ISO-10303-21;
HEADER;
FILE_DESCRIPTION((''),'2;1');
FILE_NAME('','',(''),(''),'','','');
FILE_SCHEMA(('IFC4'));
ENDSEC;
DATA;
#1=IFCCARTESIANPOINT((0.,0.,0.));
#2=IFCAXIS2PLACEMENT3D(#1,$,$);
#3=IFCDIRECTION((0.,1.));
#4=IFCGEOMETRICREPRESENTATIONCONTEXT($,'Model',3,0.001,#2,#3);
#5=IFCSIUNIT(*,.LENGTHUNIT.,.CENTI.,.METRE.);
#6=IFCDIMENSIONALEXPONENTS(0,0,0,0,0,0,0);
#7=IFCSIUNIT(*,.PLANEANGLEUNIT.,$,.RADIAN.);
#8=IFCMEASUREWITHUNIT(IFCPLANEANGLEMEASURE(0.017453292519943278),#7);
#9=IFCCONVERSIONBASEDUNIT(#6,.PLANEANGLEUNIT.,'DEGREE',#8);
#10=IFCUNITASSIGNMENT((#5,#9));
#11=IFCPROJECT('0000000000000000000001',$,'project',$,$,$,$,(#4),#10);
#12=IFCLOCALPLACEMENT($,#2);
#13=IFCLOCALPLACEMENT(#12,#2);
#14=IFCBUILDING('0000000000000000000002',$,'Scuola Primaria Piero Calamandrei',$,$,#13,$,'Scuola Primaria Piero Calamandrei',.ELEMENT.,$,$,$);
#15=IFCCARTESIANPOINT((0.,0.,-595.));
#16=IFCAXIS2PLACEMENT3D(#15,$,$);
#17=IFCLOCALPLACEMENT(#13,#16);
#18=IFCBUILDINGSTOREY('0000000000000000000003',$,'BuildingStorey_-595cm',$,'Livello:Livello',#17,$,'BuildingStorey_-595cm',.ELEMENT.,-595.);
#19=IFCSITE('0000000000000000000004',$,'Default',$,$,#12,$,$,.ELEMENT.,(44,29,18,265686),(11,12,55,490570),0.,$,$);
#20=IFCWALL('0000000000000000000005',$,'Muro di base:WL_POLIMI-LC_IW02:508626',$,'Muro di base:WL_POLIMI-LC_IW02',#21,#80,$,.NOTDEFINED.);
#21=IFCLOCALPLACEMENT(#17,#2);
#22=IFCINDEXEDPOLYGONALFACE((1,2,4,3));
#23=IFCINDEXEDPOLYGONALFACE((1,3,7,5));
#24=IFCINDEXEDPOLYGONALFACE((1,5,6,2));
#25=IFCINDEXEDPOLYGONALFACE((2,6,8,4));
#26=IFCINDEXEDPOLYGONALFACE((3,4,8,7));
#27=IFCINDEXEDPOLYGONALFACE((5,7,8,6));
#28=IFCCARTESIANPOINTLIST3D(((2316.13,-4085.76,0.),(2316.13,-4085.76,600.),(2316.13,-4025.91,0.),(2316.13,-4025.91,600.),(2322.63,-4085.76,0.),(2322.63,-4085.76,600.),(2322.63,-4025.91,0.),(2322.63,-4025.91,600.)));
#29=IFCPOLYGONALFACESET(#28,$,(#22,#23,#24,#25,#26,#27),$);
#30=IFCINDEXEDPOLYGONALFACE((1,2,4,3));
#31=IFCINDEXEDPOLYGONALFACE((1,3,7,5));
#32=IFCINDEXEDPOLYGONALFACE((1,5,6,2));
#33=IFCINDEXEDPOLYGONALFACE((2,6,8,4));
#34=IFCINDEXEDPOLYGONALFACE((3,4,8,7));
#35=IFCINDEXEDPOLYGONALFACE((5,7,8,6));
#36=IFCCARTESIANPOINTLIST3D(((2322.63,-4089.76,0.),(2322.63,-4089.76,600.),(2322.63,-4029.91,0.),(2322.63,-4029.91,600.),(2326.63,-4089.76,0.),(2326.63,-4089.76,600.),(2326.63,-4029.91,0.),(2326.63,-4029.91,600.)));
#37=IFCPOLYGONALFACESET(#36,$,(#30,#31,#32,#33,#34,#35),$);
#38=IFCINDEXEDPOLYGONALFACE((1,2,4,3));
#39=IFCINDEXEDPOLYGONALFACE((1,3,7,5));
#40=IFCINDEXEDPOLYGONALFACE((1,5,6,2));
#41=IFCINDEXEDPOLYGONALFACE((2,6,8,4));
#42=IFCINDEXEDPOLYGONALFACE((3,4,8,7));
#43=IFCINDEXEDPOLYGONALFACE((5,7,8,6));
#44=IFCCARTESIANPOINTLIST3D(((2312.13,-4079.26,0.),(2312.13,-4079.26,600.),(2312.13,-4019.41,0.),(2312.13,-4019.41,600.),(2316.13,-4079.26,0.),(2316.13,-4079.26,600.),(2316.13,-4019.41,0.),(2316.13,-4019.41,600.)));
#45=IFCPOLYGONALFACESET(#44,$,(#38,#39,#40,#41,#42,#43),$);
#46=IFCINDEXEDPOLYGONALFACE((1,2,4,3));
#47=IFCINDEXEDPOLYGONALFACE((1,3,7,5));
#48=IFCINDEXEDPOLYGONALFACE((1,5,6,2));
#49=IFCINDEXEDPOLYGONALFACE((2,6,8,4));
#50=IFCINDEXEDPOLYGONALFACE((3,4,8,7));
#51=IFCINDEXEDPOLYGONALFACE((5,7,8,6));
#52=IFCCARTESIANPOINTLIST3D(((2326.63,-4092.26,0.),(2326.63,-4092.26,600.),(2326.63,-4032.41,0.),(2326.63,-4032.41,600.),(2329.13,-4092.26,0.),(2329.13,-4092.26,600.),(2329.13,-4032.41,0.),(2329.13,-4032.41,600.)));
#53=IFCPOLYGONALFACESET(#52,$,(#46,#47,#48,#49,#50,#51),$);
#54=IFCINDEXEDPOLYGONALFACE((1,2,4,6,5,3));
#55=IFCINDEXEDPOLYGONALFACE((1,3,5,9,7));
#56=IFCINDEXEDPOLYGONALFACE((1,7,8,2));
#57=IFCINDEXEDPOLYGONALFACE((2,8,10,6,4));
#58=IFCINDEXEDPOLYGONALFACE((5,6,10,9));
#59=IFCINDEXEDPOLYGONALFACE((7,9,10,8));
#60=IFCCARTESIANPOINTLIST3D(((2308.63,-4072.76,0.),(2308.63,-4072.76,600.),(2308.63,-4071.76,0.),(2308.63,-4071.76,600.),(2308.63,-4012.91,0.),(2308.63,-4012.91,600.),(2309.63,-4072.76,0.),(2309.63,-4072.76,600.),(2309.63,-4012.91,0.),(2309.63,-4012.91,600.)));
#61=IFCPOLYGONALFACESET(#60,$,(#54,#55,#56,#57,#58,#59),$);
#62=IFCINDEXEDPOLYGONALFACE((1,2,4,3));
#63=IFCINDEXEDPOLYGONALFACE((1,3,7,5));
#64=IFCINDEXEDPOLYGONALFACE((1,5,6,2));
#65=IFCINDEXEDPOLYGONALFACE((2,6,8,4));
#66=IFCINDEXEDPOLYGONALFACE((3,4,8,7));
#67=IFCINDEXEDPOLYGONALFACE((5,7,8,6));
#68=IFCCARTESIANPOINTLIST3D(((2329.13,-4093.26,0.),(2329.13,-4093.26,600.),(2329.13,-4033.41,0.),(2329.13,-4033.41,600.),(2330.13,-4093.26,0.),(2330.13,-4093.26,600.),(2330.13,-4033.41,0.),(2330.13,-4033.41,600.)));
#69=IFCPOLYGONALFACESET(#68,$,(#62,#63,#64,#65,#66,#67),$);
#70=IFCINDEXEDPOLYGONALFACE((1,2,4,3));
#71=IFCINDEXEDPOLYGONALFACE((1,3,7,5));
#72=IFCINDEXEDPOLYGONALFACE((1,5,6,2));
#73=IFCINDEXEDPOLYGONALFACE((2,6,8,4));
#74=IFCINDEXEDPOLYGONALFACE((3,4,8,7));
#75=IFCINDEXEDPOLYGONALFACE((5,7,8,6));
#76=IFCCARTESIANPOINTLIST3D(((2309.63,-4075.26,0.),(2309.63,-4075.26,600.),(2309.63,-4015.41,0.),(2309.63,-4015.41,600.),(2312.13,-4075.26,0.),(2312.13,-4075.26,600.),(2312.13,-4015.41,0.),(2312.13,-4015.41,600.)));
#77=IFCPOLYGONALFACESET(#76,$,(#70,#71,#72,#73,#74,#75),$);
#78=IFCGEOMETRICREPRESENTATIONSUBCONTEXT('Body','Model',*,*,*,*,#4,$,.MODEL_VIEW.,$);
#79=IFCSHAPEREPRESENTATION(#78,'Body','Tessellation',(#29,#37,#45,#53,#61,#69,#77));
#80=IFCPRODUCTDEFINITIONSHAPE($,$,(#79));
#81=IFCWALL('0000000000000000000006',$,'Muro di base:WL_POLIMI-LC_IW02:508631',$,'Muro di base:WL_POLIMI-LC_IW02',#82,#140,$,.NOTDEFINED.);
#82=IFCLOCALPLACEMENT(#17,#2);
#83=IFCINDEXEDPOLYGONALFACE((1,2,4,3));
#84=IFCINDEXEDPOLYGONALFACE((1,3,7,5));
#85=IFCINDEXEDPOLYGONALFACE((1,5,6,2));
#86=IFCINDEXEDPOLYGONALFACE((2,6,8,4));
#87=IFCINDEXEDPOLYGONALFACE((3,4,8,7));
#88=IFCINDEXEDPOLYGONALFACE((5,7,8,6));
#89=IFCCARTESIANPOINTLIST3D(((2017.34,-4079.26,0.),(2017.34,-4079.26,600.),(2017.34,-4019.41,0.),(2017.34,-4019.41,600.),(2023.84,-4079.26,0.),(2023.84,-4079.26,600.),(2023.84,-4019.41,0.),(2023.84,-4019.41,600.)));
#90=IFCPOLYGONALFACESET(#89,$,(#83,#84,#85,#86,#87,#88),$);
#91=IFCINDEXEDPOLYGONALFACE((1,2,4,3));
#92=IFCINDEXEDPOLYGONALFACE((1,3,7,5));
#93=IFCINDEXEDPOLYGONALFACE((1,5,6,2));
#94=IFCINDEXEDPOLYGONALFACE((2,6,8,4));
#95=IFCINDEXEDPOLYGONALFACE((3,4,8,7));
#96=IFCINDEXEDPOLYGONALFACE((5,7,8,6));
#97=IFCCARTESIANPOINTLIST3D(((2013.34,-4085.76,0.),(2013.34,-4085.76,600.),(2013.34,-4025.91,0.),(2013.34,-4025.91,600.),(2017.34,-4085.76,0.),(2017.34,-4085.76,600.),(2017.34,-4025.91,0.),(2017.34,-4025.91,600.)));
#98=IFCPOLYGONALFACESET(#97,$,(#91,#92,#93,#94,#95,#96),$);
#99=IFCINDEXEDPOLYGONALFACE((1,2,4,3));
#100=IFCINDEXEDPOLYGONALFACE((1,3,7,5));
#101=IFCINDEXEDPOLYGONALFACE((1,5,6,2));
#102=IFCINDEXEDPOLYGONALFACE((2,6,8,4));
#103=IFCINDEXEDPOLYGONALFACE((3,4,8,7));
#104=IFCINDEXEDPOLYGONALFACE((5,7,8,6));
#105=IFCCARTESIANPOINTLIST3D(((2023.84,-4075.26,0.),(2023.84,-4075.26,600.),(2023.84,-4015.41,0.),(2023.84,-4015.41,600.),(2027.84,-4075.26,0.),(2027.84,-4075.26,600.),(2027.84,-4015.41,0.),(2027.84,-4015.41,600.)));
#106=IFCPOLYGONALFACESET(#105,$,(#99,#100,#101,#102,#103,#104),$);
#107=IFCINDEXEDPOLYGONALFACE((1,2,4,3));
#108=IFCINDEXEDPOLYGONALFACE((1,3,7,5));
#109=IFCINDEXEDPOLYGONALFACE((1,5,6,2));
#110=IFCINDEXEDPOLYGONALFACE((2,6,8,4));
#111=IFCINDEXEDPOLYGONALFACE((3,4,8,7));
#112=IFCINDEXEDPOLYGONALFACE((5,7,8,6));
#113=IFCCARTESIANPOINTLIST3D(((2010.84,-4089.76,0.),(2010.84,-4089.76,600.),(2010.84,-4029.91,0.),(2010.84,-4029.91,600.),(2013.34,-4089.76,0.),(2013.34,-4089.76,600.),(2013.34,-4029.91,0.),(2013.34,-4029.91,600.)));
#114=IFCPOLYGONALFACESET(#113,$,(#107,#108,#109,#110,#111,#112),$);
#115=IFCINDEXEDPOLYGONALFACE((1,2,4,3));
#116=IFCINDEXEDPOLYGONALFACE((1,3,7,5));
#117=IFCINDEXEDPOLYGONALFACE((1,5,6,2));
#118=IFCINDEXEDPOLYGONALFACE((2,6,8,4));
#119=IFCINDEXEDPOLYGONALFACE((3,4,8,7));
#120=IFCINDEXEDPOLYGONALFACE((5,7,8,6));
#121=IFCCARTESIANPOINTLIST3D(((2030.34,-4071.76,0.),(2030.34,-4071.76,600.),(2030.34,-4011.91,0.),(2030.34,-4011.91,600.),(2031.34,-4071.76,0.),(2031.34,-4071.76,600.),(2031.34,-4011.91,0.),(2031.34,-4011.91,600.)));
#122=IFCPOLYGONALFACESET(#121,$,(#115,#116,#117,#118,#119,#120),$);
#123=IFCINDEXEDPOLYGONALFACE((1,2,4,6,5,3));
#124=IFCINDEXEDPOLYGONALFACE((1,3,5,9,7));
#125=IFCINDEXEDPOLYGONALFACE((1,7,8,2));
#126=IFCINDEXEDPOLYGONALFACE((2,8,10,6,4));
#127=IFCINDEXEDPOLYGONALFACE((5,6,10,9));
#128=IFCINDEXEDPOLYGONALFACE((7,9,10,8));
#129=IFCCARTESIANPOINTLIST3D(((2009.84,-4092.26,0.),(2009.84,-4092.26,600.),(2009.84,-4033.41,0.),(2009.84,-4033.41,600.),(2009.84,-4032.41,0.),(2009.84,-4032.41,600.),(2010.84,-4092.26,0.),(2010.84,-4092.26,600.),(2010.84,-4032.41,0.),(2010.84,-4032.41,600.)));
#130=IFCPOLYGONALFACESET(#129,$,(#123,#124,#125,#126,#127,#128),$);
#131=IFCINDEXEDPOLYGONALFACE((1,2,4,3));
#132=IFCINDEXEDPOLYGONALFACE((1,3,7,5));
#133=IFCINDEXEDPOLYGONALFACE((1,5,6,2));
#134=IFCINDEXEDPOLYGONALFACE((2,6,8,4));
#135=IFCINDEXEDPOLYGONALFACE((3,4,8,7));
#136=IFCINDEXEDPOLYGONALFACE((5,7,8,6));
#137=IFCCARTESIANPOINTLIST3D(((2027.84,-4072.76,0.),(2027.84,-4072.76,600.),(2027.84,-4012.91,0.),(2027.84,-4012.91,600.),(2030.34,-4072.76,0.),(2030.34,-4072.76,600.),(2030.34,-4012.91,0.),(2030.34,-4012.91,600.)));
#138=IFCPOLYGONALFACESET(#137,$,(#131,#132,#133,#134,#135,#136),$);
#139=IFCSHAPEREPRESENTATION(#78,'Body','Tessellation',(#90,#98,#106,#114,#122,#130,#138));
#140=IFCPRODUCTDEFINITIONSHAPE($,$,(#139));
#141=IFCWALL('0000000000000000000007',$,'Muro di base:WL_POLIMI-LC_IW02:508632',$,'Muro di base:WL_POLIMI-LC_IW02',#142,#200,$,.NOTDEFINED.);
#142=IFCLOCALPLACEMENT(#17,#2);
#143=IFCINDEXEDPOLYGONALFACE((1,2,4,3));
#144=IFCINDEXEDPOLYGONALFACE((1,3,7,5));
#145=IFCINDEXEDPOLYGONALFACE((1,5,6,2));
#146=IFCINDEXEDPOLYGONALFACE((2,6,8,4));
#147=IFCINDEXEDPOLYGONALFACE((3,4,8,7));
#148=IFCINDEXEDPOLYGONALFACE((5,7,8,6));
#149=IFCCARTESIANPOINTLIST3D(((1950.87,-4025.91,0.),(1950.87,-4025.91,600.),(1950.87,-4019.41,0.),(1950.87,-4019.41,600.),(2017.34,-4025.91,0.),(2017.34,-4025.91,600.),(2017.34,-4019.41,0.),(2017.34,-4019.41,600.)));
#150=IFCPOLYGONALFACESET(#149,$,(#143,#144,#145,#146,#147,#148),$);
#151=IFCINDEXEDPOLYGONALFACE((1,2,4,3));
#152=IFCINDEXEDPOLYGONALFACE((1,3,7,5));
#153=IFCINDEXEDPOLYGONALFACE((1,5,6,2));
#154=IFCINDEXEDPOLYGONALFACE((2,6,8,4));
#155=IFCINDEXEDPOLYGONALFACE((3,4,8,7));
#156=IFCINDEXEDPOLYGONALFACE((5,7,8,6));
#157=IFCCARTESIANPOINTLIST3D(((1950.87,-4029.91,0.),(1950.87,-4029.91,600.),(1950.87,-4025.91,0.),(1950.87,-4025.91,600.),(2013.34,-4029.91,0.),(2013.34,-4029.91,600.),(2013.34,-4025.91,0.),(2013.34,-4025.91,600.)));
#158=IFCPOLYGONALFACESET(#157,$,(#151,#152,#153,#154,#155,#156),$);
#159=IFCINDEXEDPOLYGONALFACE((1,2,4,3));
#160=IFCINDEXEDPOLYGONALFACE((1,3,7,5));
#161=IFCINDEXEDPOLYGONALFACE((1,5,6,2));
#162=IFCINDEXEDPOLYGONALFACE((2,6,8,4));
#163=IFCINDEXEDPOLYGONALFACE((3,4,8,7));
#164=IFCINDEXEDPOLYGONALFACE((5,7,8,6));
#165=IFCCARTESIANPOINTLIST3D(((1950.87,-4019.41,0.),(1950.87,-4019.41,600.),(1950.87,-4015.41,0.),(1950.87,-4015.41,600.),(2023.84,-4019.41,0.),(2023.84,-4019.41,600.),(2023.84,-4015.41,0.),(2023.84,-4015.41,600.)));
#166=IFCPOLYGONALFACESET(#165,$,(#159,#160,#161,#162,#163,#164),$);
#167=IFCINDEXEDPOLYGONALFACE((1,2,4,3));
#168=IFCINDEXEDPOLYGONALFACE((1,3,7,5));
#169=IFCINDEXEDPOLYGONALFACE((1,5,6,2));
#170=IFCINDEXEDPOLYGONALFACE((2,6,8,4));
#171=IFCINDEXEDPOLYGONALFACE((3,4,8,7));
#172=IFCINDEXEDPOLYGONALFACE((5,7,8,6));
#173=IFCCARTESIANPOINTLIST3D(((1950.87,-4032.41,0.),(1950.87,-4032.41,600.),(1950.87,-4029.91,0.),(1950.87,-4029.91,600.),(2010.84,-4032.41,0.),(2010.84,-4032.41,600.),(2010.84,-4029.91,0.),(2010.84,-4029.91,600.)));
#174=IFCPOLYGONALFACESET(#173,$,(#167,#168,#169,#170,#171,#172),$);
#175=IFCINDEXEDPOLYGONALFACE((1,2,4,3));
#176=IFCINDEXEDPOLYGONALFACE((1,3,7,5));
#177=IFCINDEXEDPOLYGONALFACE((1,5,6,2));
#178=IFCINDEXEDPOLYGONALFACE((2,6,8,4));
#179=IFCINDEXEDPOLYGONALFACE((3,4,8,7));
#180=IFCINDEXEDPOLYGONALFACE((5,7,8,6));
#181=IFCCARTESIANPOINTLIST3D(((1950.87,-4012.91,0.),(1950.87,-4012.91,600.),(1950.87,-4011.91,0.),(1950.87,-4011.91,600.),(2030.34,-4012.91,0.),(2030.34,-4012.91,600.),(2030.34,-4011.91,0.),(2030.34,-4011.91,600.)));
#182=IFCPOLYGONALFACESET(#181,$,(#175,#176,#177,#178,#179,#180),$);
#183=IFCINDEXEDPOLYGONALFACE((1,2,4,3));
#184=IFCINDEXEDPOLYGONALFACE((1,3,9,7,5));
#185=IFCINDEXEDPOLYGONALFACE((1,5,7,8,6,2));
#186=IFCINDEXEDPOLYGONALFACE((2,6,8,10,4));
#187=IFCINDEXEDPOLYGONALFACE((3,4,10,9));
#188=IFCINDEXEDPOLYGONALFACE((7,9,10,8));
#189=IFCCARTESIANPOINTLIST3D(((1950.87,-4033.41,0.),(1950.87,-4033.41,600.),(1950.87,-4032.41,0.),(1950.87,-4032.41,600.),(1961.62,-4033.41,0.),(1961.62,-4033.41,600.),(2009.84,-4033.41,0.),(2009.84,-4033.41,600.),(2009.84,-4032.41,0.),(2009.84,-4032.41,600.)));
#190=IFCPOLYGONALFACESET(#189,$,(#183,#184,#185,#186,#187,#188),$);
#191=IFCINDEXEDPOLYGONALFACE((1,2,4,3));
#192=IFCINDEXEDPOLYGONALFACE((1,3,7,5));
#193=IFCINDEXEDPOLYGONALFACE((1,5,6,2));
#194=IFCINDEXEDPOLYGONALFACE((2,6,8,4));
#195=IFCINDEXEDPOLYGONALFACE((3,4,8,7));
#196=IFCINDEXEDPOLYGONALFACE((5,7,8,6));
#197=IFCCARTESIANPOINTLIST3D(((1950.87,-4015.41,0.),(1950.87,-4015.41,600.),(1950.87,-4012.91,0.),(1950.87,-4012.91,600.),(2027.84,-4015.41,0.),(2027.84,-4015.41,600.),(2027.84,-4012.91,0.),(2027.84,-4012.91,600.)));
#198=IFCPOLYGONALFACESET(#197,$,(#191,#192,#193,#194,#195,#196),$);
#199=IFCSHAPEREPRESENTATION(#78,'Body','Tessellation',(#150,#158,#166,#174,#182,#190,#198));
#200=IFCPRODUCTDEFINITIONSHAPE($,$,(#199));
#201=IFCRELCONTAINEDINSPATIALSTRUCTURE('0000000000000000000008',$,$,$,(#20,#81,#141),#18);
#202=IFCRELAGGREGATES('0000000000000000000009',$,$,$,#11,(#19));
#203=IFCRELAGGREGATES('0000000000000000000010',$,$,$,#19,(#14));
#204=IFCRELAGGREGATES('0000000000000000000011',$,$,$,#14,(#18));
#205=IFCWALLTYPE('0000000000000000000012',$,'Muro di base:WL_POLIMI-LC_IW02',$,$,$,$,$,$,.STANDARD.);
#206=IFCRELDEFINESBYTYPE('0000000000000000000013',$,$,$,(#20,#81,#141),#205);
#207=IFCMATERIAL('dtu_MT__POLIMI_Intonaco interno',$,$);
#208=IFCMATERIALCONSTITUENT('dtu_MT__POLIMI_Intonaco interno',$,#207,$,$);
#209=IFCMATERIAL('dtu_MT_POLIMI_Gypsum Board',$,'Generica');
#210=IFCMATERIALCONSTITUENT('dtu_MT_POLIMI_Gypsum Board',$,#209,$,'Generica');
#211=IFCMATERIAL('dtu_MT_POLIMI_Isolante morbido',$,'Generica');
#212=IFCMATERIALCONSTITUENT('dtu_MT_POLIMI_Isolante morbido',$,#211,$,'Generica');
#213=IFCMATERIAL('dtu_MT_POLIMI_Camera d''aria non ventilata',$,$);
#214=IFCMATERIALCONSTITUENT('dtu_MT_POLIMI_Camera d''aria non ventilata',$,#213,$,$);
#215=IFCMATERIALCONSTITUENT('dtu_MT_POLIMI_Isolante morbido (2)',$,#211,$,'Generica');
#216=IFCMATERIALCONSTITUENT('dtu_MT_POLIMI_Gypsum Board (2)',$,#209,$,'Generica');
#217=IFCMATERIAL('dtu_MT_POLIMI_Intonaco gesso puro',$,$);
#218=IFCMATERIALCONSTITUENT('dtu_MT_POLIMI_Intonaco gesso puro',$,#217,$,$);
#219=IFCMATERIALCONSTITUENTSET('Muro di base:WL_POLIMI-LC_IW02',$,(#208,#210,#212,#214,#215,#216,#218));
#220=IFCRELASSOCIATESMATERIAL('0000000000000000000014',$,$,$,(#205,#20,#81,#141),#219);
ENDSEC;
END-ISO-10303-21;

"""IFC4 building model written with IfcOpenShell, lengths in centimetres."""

from ifc_helpers import new_model, entity, si_unit, converted_unit, direction, frame, origin, place, context, subcontext, project, spatial, indexed_curve, outline, extrude, material, constituent, constituent_set, type_object, element, save


model = new_model("IFC4")

# Units and contexts
model_context = context("Model", 3, precision=0.001, world=origin(), true_north=direction((0.0, 1.0)))
body_context = subcontext(model_context, "Body", "Model", "MODEL_VIEW")
ifc_project = project(units=[si_unit("LENGTHUNIT", "METRE", prefix="CENTI"), converted_unit("PLANEANGLEUNIT", "DEGREE", entity("IfcPlaneAngleMeasure", 0.017453292519943278), si_unit("PLANEANGLEUNIT", "RADIAN"), dimensions=[0, 0, 0, 0, 0, 0, 0])], contexts=[model_context])

# Site, building, storey
site_placement = place(None, origin())
site = spatial("IfcSite", under=ifc_project, at=site_placement, Name="Default", CompositionType="ELEMENT", RefLatitude=(44, 29, 18, 265686), RefLongitude=(11, 12, 55, 490570), RefElevation=0.0)
building_placement = place(site_placement, origin())
building = spatial("IfcBuilding", under=site, at=building_placement, Name="Scuola Primaria Piero Calamandrei", LongName="Scuola Primaria Piero Calamandrei", CompositionType="ELEMENT")
storey_placement = place(building_placement, frame((0.0, 0.0, -595.0)))
storey = spatial("IfcBuildingStorey", under=building, at=storey_placement, Name="BuildingStorey_-595cm", ObjectType="Livello:Livello", LongName="BuildingStorey_-595cm", CompositionType="ELEMENT", Elevation=-595.0)

# Shared definitions
ifc_material_1 = material(Name="dtu_MT__POLIMI_Intonaco interno")
ifc_constituent_1 = constituent(ifc_material_1, Name="dtu_MT__POLIMI_Intonaco interno")
ifc_material_2 = material(Name="dtu_MT_POLIMI_Gypsum Board", Category="Generica")
ifc_constituent_2 = constituent(ifc_material_2, Name="dtu_MT_POLIMI_Gypsum Board", Category="Generica")
ifc_material_3 = material(Name="dtu_MT_POLIMI_Isolante morbido", Category="Generica")
ifc_constituent_3 = constituent(ifc_material_3, Name="dtu_MT_POLIMI_Isolante morbido", Category="Generica")
ifc_material_4 = material(Name="dtu_MT_POLIMI_Camera d'aria non ventilata")
ifc_constituent_4 = constituent(ifc_material_4, Name="dtu_MT_POLIMI_Camera d'aria non ventilata")
ifc_constituent_5 = constituent(ifc_material_3, Name="dtu_MT_POLIMI_Isolante morbido (2)", Category="Generica")
ifc_constituent_6 = constituent(ifc_material_2, Name="dtu_MT_POLIMI_Gypsum Board (2)", Category="Generica")
ifc_material_5 = material(Name="dtu_MT_POLIMI_Intonaco gesso puro")
ifc_constituent_7 = constituent(ifc_material_5, Name="dtu_MT_POLIMI_Intonaco gesso puro")
ifc_constituent_set_1 = constituent_set(constituents=[ifc_constituent_1, ifc_constituent_2, ifc_constituent_3, ifc_constituent_4, ifc_constituent_5, ifc_constituent_6, ifc_constituent_7], Name="Muro di base:WL_POLIMI-LC_IW02")
wall_type_1 = type_object("IfcWallType", Name="Muro di base:WL_POLIMI-LC_IW02", PredefinedType="STANDARD", material=ifc_constituent_set_1)

# Wall
wall_1_placement = place(storey_placement, frame((2319.38, -4033.41, 0.0), z_axis=(0.0, 0.0, 1.0), x_axis=(0.0, -1.0, 0.0)))
element("IfcWall", 1, at=wall_1_placement, inside=storey, type_object=wall_type_1, material=ifc_constituent_set_1, Name="Muro di base:WL_POLIMI-LC_IW02:508626", ObjectType="Muro di base:WL_POLIMI-LC_IW02", PredefinedType="NOTDEFINED", context=body_context, shape_type="SweptSolid", body=[
    extrude(outline(indexed_curve([(-29.93, -3.25), (29.93, -3.25), (29.93, 3.25), (-29.93, 3.25), (-29.93, -3.25)], self_intersect=False)), frame((22.43, 0.0, 0.0)), (0.0, 0.0, 1.0), 600.0),
    extrude(outline(indexed_curve([(-29.93, -2.0), (29.93, -2.0), (29.93, 2.0), (-29.93, 2.0), (-29.93, -2.0)], self_intersect=False)), frame((26.43, 5.25, 0.0)), (0.0, 0.0, 1.0), 600.0),
    extrude(outline(indexed_curve([(-29.93, -2.0), (29.93, -2.0), (29.93, 2.0), (-29.93, 2.0), (-29.93, -2.0)], self_intersect=False)), frame((15.93, -5.25, 0.0)), (0.0, 0.0, 1.0), 600.0),
    extrude(outline(indexed_curve([(-29.93, -1.25), (29.93, -1.25), (29.93, 1.25), (-29.93, 1.25), (-29.93, -1.25)], self_intersect=False)), frame((28.93, 8.5, 0.0)), (0.0, 0.0, 1.0), 600.0),
    extrude(outline(indexed_curve([(23.14, -0.4), (24.14, -0.4), (24.14, 0.6), (-35.71, 0.6), (-35.71, -0.4), (23.14, -0.4)], self_intersect=False)), frame((15.21, -10.35, 0.0)), (0.0, 0.0, 1.0), 600.0),
    extrude(outline(indexed_curve([(-0.5, -29.93), (0.5, -29.93), (0.5, 29.93), (-0.5, 29.93), (-0.5, -29.93)], self_intersect=False)), frame((29.93, 10.25, 0.0), z_axis=(0.0, 0.0, 1.0), x_axis=(0.0, -1.0, 0.0)), (0.0, 0.0, 1.0), 600.0),
    extrude(outline(indexed_curve([(-29.93, -1.25), (29.93, -1.25), (29.93, 1.25), (-29.93, 1.25), (-29.93, -1.25)], self_intersect=False)), frame((11.93, -8.5, 0.0)), (0.0, 0.0, 1.0), 600.0),
])

# Walls
wall_2_placement = place(storey_placement, frame((2020.59, -4071.76, 0.0), z_axis=(0.0, 0.0, 1.0), x_axis=(0.0, 1.0, 0.0)))
element("IfcWall", 2, at=wall_2_placement, inside=storey, type_object=wall_type_1, material=ifc_constituent_set_1, Name="Muro di base:WL_POLIMI-LC_IW02:508631", ObjectType="Muro di base:WL_POLIMI-LC_IW02", PredefinedType="NOTDEFINED", context=body_context, shape_type="SweptSolid", body=[
    extrude(outline(indexed_curve([(-29.93, -3.25), (29.93, -3.25), (29.93, 3.25), (-29.93, 3.25), (-29.93, -3.25)], self_intersect=False)), frame((22.43, 0.0, 0.0)), (0.0, 0.0, 1.0), 600.0),
    extrude(outline(indexed_curve([(-29.93, -2.0), (29.93, -2.0), (29.93, 2.0), (-29.93, 2.0), (-29.93, -2.0)], self_intersect=False)), frame((15.93, 5.25, 0.0)), (0.0, 0.0, 1.0), 600.0),
    extrude(outline(indexed_curve([(-29.93, -2.0), (29.93, -2.0), (29.93, 2.0), (-29.93, 2.0), (-29.93, -2.0)], self_intersect=False)), frame((26.43, -5.25, 0.0)), (0.0, 0.0, 1.0), 600.0),
    extrude(outline(indexed_curve([(-29.93, -1.25), (29.93, -1.25), (29.93, 1.25), (-29.93, 1.25), (-29.93, -1.25)], self_intersect=False)), frame((11.93, 8.5, 0.0)), (0.0, 0.0, 1.0), 600.0),
    extrude(outline(indexed_curve([(-0.5, -29.93), (0.5, -29.93), (0.5, 29.93), (-0.5, 29.93), (-0.5, -29.93)], self_intersect=False)), frame((29.93, -10.25, 0.0), z_axis=(0.0, 0.0, 1.0), x_axis=(0.0, 1.0, 0.0)), (0.0, 0.0, 1.0), 600.0),
    extrude(outline(indexed_curve([(-23.14, -0.4), (35.71, -0.4), (35.71, 0.6), (-24.14, 0.6), (-24.14, -0.4), (-23.14, -0.4)], self_intersect=False)), frame((15.21, 10.35, 0.0), z_axis=(0.0, 0.0, 1.0), x_axis=(-1.0, 0.0, 0.0)), (0.0, 0.0, 1.0), 600.0),
    extrude(outline(indexed_curve([(-29.93, -1.25), (29.93, -1.25), (29.93, 1.25), (-29.93, 1.25), (-29.93, -1.25)], self_intersect=False)), frame((28.93, -8.5, 0.0)), (0.0, 0.0, 1.0), 600.0),
])
wall_3_placement = place(storey_placement, frame((2009.84, -4022.66, 0.0), z_axis=(0.0, 0.0, 1.0), x_axis=(-1.0, 0.0, 0.0)))
element("IfcWall", 3, at=wall_3_placement, inside=storey, type_object=wall_type_1, material=ifc_constituent_set_1, Name="Muro di base:WL_POLIMI-LC_IW02:508632", ObjectType="Muro di base:WL_POLIMI-LC_IW02", PredefinedType="NOTDEFINED", context=body_context, shape_type="SweptSolid", body=[
    extrude(outline(indexed_curve([(-33.23, -3.25), (33.23, -3.25), (33.23, 3.25), (-33.23, 3.25), (-33.23, -3.25)], self_intersect=False)), frame((25.73, 0.0, 0.0)), (0.0, 0.0, 1.0), 600.0),
    extrude(outline(indexed_curve([(-31.23, -2.0), (31.23, -2.0), (31.23, 2.0), (-31.23, 2.0), (-31.23, -2.0)], self_intersect=False)), frame((27.73, 5.25, 0.0)), (0.0, 0.0, 1.0), 600.0),
    extrude(outline(indexed_curve([(-36.48, -2.0), (36.48, -2.0), (36.48, 2.0), (-36.48, 2.0), (-36.48, -2.0)], self_intersect=False)), frame((22.48, -5.25, 0.0)), (0.0, 0.0, 1.0), 600.0),
    extrude(outline(indexed_curve([(-29.98, -1.25), (29.98, -1.25), (29.98, 1.25), (-29.98, 1.25), (-29.98, -1.25)], self_intersect=False)), frame((28.98, 8.5, 0.0)), (0.0, 0.0, 1.0), 600.0),
    extrude(outline(indexed_curve([(-0.5, -39.73), (0.5, -39.73), (0.5, 39.73), (-0.5, 39.73), (-0.5, -39.73)], self_intersect=False)), frame((19.23, -10.25, 0.0), z_axis=(0.0, 0.0, 1.0), x_axis=(0.0, 1.0, 0.0)), (0.0, 0.0, 1.0), 600.0),
    extrude(outline(indexed_curve([(-14.99, -0.4), (33.23, -0.4), (33.23, 0.6), (-25.74, 0.6), (-25.74, -0.4), (-14.99, -0.4)], self_intersect=False)), frame((33.23, 10.35, 0.0), z_axis=(0.0, 0.0, 1.0), x_axis=(-1.0, 0.0, 0.0)), (0.0, 0.0, 1.0), 600.0),
    extrude(outline(indexed_curve([(-38.48, -1.25), (38.48, -1.25), (38.48, 1.25), (-38.48, 1.25), (-38.48, -1.25)], self_intersect=False)), frame((20.48, -8.5, 0.0)), (0.0, 0.0, 1.0), 600.0),
])

save(model, "model.ifc")
